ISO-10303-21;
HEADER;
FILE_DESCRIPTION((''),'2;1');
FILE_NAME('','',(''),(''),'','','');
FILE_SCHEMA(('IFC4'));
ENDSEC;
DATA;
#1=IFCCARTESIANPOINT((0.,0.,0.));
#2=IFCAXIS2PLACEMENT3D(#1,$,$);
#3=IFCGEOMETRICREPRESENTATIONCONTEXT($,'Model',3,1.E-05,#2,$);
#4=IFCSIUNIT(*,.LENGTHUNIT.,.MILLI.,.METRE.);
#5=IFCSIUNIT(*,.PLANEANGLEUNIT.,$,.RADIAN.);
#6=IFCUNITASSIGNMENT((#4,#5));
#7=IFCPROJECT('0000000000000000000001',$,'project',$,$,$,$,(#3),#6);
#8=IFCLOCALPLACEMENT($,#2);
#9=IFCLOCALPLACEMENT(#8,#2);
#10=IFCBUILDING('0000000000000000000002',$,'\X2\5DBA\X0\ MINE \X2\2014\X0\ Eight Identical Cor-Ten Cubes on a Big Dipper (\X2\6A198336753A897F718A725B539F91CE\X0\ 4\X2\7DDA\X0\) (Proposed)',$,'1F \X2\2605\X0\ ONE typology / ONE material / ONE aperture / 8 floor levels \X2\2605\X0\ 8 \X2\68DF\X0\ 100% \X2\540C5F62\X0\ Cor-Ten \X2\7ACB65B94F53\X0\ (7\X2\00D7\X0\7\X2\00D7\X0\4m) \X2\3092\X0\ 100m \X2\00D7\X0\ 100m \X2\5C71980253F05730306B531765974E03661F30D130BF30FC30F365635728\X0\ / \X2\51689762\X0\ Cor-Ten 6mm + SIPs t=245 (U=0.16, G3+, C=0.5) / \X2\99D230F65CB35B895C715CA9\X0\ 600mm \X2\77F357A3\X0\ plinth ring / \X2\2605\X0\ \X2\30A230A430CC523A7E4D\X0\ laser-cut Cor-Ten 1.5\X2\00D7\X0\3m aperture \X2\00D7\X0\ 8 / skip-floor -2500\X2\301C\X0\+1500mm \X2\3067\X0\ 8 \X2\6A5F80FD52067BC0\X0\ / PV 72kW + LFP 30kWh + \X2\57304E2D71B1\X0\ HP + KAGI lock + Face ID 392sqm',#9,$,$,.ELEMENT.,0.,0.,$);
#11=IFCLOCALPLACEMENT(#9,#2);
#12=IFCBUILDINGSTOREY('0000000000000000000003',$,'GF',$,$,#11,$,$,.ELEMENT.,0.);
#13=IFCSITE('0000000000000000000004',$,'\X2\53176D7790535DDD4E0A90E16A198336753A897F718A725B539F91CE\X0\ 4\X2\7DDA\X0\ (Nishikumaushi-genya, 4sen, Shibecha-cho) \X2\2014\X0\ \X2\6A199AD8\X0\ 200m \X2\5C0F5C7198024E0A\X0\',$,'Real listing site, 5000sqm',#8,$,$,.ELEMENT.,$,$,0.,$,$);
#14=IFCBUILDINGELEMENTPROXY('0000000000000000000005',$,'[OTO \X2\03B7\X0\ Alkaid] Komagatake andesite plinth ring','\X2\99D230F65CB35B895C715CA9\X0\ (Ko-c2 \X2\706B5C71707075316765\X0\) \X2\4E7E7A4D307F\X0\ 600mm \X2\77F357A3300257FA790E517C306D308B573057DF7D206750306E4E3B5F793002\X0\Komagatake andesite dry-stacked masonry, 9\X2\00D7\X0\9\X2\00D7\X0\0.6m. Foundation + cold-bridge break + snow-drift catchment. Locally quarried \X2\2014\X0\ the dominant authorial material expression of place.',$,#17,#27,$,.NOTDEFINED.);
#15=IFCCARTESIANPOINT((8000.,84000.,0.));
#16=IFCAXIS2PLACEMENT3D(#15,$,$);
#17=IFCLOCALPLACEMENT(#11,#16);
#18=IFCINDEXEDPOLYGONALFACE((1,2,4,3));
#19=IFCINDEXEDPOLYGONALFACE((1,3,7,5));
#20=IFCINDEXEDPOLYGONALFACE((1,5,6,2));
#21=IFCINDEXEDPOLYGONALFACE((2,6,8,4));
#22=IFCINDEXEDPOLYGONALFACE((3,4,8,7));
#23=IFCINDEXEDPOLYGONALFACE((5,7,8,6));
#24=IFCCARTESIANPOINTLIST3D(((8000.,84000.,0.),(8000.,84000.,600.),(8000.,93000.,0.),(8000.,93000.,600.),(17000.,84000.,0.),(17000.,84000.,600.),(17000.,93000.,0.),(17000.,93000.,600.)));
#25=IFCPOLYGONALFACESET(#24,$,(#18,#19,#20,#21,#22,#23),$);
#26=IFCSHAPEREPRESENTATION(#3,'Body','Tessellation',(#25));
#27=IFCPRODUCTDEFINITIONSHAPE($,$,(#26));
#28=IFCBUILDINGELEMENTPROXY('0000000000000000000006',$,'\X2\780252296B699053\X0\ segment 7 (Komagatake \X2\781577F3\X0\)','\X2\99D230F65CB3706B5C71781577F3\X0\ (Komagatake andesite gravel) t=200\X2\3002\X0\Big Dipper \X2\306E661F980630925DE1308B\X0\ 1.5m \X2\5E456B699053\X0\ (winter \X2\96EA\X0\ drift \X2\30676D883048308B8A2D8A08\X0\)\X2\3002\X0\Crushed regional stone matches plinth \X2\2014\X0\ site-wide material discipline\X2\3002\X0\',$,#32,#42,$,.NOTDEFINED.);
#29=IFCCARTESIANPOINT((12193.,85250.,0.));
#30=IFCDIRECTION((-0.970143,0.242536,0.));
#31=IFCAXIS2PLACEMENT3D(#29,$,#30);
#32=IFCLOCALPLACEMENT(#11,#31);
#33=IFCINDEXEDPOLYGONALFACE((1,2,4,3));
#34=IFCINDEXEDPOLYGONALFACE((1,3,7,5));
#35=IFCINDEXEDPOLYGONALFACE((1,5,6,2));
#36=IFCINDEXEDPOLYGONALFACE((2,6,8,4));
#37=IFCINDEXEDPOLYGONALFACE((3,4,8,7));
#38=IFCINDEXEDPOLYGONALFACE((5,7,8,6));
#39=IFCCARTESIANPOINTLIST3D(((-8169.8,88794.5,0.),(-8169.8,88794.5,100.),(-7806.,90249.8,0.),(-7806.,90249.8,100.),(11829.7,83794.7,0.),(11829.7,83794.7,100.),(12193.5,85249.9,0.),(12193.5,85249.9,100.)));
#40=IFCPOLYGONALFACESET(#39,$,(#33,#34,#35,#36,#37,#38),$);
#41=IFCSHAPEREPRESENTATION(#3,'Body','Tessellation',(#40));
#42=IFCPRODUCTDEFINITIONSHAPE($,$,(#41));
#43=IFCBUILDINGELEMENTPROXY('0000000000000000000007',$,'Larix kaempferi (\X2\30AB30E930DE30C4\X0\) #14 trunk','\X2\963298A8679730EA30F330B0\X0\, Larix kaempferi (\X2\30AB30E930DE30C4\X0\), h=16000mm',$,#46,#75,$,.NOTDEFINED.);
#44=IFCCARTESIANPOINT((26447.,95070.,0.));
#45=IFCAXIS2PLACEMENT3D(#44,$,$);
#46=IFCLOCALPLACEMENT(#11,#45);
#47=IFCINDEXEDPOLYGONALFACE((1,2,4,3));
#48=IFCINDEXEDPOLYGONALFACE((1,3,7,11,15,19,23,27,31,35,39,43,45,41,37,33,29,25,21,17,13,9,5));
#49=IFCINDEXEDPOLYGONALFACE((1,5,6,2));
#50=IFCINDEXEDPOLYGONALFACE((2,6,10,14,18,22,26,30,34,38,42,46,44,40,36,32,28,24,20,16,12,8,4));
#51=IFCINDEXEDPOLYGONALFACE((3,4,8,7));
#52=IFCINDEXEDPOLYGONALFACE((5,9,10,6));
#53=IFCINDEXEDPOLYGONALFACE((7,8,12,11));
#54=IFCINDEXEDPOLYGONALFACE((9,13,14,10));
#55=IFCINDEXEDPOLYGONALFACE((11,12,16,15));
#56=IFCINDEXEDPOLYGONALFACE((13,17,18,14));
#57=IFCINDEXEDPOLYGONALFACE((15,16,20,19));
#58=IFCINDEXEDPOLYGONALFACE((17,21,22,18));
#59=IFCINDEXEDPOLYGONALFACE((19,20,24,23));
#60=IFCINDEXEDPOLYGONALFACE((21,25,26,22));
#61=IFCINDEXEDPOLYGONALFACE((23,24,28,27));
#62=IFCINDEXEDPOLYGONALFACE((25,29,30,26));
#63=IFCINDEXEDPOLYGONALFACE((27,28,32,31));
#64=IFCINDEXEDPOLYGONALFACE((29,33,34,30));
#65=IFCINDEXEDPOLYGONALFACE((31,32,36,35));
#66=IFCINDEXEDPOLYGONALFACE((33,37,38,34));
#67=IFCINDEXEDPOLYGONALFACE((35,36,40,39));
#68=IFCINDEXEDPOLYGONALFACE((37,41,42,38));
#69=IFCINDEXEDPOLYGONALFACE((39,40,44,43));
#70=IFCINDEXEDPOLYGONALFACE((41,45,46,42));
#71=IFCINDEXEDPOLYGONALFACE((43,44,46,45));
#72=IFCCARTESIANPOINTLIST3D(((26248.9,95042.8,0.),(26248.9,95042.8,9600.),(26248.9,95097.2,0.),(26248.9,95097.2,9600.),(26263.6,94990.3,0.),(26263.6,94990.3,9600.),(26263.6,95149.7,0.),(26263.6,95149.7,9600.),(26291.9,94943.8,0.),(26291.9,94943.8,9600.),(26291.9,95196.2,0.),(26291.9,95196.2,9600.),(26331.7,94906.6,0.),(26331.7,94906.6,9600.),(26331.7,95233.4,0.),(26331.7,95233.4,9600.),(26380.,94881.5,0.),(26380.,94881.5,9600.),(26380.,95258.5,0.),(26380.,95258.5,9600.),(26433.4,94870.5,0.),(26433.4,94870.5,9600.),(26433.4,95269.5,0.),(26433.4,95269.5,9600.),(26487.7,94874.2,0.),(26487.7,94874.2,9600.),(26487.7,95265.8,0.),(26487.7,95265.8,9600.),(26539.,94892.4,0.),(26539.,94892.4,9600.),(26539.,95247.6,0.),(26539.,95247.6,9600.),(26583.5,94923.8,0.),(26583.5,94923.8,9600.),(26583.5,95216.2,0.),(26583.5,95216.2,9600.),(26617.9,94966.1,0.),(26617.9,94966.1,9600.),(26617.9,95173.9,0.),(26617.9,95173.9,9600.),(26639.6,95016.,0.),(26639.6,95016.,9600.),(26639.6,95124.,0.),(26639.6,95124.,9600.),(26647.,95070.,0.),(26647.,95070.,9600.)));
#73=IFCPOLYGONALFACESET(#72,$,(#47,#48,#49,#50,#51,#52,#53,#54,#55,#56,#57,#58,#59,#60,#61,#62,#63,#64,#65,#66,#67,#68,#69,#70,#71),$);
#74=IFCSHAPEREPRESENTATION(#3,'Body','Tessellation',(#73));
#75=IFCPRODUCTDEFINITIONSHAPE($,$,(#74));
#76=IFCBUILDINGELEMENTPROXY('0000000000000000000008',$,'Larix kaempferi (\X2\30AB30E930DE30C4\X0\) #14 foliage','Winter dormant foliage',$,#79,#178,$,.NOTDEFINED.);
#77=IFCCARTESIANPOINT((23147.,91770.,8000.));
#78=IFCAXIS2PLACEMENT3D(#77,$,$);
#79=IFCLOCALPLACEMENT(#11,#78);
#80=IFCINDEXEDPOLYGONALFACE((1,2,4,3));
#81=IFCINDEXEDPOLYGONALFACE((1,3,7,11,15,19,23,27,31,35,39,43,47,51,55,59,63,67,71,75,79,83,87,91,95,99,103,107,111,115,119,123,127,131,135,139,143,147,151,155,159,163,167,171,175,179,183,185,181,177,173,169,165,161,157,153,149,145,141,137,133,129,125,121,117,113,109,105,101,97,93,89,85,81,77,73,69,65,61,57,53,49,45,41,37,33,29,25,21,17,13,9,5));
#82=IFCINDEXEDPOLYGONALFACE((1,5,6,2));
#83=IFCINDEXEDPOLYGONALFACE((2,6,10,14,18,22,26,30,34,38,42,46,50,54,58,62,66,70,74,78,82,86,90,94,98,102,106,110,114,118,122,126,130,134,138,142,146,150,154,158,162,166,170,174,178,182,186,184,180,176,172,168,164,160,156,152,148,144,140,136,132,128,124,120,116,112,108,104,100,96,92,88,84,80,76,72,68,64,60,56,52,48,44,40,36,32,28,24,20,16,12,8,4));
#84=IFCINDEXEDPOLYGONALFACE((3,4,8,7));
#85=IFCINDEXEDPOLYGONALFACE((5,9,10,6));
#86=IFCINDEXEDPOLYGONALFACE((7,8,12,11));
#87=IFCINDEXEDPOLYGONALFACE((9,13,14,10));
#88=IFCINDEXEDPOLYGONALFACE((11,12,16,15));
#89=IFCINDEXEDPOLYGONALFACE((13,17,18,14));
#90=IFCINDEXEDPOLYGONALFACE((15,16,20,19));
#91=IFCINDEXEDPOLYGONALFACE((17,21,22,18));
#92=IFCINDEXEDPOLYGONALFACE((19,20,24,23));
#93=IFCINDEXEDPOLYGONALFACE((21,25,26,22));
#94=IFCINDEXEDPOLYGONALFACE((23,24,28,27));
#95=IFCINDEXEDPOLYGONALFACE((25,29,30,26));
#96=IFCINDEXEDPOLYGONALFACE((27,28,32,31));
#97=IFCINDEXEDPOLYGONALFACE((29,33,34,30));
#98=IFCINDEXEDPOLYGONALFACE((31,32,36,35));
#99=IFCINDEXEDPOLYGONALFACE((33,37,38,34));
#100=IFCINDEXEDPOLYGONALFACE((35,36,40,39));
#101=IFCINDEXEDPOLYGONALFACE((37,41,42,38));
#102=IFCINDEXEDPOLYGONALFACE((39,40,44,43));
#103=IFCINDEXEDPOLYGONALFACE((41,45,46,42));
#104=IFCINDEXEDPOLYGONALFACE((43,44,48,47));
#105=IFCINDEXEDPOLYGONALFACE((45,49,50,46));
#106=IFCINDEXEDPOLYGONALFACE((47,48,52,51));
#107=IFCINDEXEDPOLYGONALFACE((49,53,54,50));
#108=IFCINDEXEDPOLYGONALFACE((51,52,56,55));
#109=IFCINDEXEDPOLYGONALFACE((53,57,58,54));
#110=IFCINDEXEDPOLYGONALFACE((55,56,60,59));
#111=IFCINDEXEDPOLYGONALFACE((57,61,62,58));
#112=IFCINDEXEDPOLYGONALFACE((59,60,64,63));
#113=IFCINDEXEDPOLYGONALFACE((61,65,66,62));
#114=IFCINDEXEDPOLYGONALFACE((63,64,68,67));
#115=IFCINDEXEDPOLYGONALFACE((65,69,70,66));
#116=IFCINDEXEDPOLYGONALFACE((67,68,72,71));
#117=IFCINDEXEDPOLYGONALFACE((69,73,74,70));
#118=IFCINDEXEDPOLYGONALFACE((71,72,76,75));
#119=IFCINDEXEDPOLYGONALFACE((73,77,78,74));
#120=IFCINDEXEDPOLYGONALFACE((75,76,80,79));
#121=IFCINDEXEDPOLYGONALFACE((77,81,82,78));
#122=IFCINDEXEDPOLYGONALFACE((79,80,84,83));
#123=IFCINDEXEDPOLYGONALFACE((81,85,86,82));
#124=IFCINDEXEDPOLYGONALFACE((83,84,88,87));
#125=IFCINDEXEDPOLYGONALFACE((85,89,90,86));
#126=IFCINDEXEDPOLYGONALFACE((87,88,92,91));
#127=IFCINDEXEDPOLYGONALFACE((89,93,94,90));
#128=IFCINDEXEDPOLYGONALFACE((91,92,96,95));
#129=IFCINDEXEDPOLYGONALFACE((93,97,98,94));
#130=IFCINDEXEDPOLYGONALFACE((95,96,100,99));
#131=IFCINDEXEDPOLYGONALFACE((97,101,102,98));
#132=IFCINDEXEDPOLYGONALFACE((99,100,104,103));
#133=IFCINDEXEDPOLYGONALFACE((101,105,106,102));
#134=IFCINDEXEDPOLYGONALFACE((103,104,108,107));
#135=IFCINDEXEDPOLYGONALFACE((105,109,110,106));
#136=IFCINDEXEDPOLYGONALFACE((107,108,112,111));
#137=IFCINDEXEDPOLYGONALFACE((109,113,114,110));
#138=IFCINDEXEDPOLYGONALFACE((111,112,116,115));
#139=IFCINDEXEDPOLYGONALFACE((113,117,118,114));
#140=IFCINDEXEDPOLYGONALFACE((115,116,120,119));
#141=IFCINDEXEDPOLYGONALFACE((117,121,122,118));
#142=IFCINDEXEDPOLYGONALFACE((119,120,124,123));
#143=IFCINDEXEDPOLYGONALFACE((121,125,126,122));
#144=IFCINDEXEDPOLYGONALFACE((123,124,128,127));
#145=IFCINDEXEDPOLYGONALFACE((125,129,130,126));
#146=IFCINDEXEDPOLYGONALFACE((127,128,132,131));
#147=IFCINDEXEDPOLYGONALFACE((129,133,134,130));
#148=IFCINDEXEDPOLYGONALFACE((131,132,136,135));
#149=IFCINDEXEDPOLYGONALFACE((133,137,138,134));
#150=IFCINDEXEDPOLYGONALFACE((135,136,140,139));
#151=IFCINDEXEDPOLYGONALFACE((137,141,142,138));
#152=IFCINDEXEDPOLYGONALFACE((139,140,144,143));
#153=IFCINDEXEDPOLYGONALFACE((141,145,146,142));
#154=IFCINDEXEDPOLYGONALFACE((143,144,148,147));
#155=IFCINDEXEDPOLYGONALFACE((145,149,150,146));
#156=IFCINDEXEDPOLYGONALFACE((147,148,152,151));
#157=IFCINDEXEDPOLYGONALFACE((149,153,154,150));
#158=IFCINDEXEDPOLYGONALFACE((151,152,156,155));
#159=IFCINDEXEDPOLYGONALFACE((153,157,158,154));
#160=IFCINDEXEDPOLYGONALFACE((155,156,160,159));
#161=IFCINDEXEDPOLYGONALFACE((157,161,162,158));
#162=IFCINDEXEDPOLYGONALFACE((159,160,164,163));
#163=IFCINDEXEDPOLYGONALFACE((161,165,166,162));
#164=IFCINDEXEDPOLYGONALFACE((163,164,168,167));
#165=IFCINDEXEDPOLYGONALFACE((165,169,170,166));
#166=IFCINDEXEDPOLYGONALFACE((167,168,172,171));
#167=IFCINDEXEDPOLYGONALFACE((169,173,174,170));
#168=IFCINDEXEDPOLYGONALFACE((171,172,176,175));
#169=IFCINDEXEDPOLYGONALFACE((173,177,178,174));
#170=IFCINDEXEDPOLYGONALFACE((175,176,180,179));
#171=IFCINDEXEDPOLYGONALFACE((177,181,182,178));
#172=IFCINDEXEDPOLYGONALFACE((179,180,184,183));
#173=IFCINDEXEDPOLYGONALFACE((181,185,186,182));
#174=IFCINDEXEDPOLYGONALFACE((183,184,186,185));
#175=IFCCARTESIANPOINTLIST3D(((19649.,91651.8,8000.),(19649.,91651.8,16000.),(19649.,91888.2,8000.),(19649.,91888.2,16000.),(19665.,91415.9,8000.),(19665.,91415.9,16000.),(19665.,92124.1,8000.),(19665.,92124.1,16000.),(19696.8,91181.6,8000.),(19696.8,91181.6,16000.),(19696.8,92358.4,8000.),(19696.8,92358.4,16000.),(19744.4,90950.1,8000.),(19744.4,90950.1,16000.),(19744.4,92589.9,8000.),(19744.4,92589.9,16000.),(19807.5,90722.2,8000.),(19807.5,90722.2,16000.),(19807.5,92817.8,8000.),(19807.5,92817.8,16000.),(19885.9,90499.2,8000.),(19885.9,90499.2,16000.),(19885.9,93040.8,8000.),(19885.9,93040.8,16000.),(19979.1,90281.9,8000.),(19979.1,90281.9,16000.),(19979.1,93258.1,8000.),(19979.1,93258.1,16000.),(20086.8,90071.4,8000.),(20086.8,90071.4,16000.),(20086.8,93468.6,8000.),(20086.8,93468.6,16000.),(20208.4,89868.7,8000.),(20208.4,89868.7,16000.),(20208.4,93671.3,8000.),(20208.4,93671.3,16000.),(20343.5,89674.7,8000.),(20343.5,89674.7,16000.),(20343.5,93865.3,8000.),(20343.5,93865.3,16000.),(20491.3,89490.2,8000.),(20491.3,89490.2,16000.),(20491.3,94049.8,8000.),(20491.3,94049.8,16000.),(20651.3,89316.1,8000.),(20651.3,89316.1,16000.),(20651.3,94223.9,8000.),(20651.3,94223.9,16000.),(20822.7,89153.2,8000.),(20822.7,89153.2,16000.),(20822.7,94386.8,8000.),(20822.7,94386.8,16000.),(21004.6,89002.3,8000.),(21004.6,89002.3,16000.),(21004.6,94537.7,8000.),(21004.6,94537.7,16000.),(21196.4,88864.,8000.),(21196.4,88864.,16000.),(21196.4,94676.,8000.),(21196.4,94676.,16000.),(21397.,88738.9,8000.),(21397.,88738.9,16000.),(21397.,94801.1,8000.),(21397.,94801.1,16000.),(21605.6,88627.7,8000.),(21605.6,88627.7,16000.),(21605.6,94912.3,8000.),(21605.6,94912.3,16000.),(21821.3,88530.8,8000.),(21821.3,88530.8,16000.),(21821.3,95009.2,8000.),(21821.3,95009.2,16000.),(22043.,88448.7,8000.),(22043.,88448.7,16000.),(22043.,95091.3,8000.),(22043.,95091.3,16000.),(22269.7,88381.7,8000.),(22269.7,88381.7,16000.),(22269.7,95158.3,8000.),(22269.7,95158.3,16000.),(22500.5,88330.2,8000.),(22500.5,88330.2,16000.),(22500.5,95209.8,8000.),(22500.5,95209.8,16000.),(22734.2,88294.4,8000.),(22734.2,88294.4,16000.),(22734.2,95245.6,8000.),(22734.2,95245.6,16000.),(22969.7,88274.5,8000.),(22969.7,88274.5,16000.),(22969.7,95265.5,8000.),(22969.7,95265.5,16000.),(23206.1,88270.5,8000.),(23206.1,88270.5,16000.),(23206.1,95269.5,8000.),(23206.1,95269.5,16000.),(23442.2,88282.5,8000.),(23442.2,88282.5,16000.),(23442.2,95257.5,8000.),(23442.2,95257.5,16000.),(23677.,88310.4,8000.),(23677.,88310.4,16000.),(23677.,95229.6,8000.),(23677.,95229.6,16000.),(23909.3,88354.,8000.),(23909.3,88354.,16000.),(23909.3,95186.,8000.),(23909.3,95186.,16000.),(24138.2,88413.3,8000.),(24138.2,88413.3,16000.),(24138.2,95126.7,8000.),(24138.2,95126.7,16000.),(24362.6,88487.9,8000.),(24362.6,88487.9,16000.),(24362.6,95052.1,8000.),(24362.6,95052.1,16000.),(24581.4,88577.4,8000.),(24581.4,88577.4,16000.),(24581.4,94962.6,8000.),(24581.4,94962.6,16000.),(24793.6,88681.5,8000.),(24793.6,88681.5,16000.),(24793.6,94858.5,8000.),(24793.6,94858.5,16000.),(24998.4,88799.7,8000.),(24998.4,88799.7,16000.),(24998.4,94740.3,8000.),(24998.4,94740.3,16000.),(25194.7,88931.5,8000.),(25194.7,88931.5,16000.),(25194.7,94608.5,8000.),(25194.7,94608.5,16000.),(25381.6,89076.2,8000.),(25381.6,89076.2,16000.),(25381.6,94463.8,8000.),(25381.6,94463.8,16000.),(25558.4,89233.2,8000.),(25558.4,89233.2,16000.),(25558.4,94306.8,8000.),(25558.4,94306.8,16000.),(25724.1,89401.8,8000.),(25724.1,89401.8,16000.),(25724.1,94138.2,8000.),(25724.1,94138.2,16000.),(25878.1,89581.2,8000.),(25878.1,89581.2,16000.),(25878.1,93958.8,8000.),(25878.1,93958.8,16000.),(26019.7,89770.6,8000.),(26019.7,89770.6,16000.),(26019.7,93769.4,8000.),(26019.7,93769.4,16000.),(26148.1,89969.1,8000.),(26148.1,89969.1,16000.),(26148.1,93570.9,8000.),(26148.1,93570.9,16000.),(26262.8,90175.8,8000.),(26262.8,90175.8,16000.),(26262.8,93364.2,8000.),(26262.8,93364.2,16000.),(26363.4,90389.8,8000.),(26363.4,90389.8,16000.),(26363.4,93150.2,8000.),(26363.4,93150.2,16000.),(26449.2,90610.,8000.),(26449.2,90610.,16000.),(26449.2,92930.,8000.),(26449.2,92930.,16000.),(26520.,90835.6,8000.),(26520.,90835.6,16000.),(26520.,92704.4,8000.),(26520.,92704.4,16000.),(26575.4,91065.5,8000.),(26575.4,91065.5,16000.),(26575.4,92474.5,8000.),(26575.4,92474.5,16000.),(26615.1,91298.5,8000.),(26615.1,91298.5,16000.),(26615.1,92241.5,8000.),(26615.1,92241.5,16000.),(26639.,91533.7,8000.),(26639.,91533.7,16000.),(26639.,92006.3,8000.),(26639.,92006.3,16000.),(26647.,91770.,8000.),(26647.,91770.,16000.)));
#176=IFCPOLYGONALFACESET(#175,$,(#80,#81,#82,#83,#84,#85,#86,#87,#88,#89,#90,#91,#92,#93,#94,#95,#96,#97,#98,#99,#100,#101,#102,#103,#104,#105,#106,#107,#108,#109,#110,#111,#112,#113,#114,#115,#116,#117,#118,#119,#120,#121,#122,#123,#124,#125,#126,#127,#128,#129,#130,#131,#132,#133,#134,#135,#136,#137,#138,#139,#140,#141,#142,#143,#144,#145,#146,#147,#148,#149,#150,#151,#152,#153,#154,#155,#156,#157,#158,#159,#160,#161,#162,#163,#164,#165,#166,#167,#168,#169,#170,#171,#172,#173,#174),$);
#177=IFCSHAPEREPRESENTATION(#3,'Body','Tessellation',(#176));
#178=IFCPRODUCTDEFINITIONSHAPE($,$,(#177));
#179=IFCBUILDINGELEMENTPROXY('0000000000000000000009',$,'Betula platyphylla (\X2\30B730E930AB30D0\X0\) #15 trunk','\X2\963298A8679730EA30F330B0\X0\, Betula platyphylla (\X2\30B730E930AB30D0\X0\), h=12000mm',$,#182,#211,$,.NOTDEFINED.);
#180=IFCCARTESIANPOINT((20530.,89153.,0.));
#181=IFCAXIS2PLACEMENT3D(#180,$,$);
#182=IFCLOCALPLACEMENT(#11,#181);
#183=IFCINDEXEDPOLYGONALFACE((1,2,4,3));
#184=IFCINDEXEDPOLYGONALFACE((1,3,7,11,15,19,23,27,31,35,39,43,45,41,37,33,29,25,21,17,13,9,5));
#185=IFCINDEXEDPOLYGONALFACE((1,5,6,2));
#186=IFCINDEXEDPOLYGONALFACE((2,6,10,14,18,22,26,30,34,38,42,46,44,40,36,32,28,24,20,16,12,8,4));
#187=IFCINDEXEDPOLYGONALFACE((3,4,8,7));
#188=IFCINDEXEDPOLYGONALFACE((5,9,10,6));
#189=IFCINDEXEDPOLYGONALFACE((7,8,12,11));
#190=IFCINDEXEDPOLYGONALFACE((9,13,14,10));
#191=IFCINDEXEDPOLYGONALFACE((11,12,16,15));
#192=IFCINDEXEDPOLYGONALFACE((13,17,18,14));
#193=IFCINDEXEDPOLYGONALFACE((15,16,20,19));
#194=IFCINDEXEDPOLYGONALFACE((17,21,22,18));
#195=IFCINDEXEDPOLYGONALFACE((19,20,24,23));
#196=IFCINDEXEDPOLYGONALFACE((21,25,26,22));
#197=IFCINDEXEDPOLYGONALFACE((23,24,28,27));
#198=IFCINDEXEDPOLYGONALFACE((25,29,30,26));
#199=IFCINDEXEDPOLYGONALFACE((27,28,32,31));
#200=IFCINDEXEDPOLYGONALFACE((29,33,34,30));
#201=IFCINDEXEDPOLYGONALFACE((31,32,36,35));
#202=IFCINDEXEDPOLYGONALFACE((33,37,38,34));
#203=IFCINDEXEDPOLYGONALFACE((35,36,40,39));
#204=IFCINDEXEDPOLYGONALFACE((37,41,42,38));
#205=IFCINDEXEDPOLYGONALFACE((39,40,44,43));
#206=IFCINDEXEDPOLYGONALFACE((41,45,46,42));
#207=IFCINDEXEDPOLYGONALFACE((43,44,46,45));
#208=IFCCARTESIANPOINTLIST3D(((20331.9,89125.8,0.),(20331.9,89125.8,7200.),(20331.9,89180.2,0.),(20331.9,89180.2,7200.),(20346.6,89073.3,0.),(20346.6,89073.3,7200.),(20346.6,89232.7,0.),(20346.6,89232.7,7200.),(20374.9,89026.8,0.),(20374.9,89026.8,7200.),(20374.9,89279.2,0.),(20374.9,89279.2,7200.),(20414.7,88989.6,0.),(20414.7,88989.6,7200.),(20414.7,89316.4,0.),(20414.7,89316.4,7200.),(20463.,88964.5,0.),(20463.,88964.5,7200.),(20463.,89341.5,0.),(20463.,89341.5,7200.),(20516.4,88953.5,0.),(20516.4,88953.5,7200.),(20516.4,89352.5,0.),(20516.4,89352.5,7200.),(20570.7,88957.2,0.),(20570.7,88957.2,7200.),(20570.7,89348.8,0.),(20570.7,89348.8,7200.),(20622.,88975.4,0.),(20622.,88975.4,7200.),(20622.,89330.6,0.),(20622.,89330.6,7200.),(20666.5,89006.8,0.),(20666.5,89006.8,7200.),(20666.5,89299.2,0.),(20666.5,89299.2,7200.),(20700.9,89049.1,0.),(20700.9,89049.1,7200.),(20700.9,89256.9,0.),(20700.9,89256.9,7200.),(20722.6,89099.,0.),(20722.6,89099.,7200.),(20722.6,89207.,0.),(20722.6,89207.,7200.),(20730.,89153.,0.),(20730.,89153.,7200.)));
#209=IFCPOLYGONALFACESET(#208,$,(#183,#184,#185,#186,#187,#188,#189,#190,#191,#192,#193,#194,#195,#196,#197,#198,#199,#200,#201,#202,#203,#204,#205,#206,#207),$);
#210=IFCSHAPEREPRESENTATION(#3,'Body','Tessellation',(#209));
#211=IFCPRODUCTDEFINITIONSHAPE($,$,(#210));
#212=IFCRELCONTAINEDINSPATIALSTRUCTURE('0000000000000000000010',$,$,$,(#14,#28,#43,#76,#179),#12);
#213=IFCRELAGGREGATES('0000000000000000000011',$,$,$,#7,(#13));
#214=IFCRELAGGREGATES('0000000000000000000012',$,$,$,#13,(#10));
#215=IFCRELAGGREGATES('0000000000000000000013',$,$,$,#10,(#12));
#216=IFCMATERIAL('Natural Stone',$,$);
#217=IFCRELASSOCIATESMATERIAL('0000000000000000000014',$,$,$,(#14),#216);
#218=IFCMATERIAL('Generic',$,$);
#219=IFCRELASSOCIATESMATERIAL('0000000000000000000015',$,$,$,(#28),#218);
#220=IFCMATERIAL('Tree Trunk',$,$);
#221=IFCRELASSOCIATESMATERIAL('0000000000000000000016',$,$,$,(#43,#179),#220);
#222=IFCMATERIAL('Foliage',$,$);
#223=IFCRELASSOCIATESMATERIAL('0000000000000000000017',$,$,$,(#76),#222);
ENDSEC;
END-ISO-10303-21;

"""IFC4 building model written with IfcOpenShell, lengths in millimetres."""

from ifc_helpers import new_model, si_unit, frame, frame_2d, origin, origin_2d, place, context, project, spatial, rectangle, circle, extrude, material, element, save


model = new_model("IFC4")

# Units and contexts
model_context = context("Model", 3, precision=1e-05, world=origin())
ifc_project = project(units=[si_unit("LENGTHUNIT", "METRE", prefix="MILLI"), si_unit("PLANEANGLEUNIT", "RADIAN")], contexts=[model_context])

# Site, building, storey
site_placement = place(None, origin())
site = spatial("IfcSite", under=ifc_project, at=site_placement, Name="北海道川上郡標茶町西熊牛原野 4線 (Nishikumaushi-genya, 4sen, Shibecha-cho) — 標高 200m 小山頂上", ObjectType="Real listing site, 5000sqm", CompositionType="ELEMENT", RefElevation=0.0)
building_placement = place(site_placement, origin())
building = spatial("IfcBuilding", under=site, at=building_placement, Name="嶺 MINE — Eight Identical Cor-Ten Cubes on a Big Dipper (標茶町西熊牛原野 4線) (Proposed)", ObjectType="1F ★ ONE typology / ONE material / ONE aperture / 8 floor levels ★ 8 棟 100% 同形 Cor-Ten 立方体 (7×7×4m) を 100m × 100m 山頂台地に北斗七星パターン散在 / 全面 Cor-Ten 6mm + SIPs t=245 (U=0.16, G3+, C=0.5) / 駒ヶ岳安山岩 600mm 石垣 plinth ring / ★ アイヌ刺繍 laser-cut Cor-Ten 1.5×3m aperture × 8 / skip-floor -2500〜+1500mm で 8 機能分節 / PV 72kW + LFP 30kWh + 地中熱 HP + KAGI lock + Face ID 392sqm", CompositionType="ELEMENT", ElevationOfRefHeight=0.0, ElevationOfTerrain=0.0)
storey_placement = place(building_placement, origin())
storey = spatial("IfcBuildingStorey", under=building, at=storey_placement, Name="GF", CompositionType="ELEMENT", Elevation=0.0)

# Shared definitions
ifc_material_1 = material(Name="Generic")

# Building element proxies
ifc_material_2 = material(Name="Natural Stone")
proxy_1_placement = place(storey_placement, frame((8000.0, 84000.0, 0.0)))
element("IfcBuildingElementProxy", 1, at=proxy_1_placement, inside=storey, material=ifc_material_2, Name="[OTO η Alkaid] Komagatake andesite plinth ring", Description="駒ヶ岳安山岩 (Ko-c2 火山灰由来) 乾積み 600mm 石垣。基礎兼ねる地域素材の主役。Komagatake andesite dry-stacked masonry, 9×9×0.6m. Foundation + cold-bridge break + snow-drift catchment. Locally quarried — the dominant authorial material expression of place.", PredefinedType="NOTDEFINED", context=model_context, shape_type="SweptSolid", body=[
    extrude(rectangle(XDim=9000.0, YDim=9000.0, at=frame_2d((4500.0, 4500.0))), frame((8000.0, 84000.0, 0.0)), (0.0, 0.0, 1.0), 600.0),
])
proxy_2_placement = place(storey_placement, frame((12193.0, 85250.0, 0.0), x_axis=(-0.970143, 0.242536, 0.0)))
element("IfcBuildingElementProxy", 2, at=proxy_2_placement, inside=storey, material=ifc_material_1, Name="砂利歩道 segment 7 (Komagatake 砕石)", Description="駒ヶ岳火山砕石 (Komagatake andesite gravel) t=200。Big Dipper の星順を巡る 1.5m 幅歩道 (winter 雪 drift で消える設計)。Crushed regional stone matches plinth — site-wide material discipline。", PredefinedType="NOTDEFINED", context=model_context, shape_type="SweptSolid", body=[
    extrude(rectangle(XDim=20615.0, YDim=1500.0, at=frame_2d((10307.0, 750.0))), frame((12193.0, 85250.0, 0.0), x_axis=(-0.970143, 0.242536, 0.0)), (0.0, 0.0, 1.0), 100.0),
])
ifc_material_3 = material(Name="Tree Trunk")
proxy_3_placement = place(storey_placement, frame((26447.0, 95070.0, 0.0)))
element("IfcBuildingElementProxy", 3, at=proxy_3_placement, inside=storey, material=ifc_material_3, Name="Larix kaempferi (カラマツ) #14 trunk", Description="防風林リング, Larix kaempferi (カラマツ), h=16000mm", PredefinedType="NOTDEFINED", context=model_context, shape_type="SweptSolid", body=[
    extrude(circle(Radius=200.0, at=origin_2d()), frame((26447.0, 95070.0, 0.0)), (0.0, 0.0, 1.0), 9600.0),
])
ifc_material_4 = material(Name="Foliage")
proxy_4_placement = place(storey_placement, frame((23147.0, 91770.0, 8000.0)))
element("IfcBuildingElementProxy", 4, at=proxy_4_placement, inside=storey, material=ifc_material_4, Name="Larix kaempferi (カラマツ) #14 foliage", Description="Winter dormant foliage", PredefinedType="NOTDEFINED", context=model_context, shape_type="SweptSolid", body=[
    extrude(circle(Radius=3500.0, at=origin_2d()), frame((23147.0, 91770.0, 8000.0)), (0.0, 0.0, 1.0), 8000.0),
])
proxy_5_placement = place(storey_placement, frame((20530.0, 89153.0, 0.0)))
element("IfcBuildingElementProxy", 5, at=proxy_5_placement, inside=storey, material=ifc_material_3, Name="Betula platyphylla (シラカバ) #15 trunk", Description="防風林リング, Betula platyphylla (シラカバ), h=12000mm", PredefinedType="NOTDEFINED", context=model_context, shape_type="SweptSolid", body=[
    extrude(circle(Radius=200.0, at=origin_2d()), frame((20530.0, 89153.0, 0.0)), (0.0, 0.0, 1.0), 7200.0),
])

save(model, "model.ifc")
